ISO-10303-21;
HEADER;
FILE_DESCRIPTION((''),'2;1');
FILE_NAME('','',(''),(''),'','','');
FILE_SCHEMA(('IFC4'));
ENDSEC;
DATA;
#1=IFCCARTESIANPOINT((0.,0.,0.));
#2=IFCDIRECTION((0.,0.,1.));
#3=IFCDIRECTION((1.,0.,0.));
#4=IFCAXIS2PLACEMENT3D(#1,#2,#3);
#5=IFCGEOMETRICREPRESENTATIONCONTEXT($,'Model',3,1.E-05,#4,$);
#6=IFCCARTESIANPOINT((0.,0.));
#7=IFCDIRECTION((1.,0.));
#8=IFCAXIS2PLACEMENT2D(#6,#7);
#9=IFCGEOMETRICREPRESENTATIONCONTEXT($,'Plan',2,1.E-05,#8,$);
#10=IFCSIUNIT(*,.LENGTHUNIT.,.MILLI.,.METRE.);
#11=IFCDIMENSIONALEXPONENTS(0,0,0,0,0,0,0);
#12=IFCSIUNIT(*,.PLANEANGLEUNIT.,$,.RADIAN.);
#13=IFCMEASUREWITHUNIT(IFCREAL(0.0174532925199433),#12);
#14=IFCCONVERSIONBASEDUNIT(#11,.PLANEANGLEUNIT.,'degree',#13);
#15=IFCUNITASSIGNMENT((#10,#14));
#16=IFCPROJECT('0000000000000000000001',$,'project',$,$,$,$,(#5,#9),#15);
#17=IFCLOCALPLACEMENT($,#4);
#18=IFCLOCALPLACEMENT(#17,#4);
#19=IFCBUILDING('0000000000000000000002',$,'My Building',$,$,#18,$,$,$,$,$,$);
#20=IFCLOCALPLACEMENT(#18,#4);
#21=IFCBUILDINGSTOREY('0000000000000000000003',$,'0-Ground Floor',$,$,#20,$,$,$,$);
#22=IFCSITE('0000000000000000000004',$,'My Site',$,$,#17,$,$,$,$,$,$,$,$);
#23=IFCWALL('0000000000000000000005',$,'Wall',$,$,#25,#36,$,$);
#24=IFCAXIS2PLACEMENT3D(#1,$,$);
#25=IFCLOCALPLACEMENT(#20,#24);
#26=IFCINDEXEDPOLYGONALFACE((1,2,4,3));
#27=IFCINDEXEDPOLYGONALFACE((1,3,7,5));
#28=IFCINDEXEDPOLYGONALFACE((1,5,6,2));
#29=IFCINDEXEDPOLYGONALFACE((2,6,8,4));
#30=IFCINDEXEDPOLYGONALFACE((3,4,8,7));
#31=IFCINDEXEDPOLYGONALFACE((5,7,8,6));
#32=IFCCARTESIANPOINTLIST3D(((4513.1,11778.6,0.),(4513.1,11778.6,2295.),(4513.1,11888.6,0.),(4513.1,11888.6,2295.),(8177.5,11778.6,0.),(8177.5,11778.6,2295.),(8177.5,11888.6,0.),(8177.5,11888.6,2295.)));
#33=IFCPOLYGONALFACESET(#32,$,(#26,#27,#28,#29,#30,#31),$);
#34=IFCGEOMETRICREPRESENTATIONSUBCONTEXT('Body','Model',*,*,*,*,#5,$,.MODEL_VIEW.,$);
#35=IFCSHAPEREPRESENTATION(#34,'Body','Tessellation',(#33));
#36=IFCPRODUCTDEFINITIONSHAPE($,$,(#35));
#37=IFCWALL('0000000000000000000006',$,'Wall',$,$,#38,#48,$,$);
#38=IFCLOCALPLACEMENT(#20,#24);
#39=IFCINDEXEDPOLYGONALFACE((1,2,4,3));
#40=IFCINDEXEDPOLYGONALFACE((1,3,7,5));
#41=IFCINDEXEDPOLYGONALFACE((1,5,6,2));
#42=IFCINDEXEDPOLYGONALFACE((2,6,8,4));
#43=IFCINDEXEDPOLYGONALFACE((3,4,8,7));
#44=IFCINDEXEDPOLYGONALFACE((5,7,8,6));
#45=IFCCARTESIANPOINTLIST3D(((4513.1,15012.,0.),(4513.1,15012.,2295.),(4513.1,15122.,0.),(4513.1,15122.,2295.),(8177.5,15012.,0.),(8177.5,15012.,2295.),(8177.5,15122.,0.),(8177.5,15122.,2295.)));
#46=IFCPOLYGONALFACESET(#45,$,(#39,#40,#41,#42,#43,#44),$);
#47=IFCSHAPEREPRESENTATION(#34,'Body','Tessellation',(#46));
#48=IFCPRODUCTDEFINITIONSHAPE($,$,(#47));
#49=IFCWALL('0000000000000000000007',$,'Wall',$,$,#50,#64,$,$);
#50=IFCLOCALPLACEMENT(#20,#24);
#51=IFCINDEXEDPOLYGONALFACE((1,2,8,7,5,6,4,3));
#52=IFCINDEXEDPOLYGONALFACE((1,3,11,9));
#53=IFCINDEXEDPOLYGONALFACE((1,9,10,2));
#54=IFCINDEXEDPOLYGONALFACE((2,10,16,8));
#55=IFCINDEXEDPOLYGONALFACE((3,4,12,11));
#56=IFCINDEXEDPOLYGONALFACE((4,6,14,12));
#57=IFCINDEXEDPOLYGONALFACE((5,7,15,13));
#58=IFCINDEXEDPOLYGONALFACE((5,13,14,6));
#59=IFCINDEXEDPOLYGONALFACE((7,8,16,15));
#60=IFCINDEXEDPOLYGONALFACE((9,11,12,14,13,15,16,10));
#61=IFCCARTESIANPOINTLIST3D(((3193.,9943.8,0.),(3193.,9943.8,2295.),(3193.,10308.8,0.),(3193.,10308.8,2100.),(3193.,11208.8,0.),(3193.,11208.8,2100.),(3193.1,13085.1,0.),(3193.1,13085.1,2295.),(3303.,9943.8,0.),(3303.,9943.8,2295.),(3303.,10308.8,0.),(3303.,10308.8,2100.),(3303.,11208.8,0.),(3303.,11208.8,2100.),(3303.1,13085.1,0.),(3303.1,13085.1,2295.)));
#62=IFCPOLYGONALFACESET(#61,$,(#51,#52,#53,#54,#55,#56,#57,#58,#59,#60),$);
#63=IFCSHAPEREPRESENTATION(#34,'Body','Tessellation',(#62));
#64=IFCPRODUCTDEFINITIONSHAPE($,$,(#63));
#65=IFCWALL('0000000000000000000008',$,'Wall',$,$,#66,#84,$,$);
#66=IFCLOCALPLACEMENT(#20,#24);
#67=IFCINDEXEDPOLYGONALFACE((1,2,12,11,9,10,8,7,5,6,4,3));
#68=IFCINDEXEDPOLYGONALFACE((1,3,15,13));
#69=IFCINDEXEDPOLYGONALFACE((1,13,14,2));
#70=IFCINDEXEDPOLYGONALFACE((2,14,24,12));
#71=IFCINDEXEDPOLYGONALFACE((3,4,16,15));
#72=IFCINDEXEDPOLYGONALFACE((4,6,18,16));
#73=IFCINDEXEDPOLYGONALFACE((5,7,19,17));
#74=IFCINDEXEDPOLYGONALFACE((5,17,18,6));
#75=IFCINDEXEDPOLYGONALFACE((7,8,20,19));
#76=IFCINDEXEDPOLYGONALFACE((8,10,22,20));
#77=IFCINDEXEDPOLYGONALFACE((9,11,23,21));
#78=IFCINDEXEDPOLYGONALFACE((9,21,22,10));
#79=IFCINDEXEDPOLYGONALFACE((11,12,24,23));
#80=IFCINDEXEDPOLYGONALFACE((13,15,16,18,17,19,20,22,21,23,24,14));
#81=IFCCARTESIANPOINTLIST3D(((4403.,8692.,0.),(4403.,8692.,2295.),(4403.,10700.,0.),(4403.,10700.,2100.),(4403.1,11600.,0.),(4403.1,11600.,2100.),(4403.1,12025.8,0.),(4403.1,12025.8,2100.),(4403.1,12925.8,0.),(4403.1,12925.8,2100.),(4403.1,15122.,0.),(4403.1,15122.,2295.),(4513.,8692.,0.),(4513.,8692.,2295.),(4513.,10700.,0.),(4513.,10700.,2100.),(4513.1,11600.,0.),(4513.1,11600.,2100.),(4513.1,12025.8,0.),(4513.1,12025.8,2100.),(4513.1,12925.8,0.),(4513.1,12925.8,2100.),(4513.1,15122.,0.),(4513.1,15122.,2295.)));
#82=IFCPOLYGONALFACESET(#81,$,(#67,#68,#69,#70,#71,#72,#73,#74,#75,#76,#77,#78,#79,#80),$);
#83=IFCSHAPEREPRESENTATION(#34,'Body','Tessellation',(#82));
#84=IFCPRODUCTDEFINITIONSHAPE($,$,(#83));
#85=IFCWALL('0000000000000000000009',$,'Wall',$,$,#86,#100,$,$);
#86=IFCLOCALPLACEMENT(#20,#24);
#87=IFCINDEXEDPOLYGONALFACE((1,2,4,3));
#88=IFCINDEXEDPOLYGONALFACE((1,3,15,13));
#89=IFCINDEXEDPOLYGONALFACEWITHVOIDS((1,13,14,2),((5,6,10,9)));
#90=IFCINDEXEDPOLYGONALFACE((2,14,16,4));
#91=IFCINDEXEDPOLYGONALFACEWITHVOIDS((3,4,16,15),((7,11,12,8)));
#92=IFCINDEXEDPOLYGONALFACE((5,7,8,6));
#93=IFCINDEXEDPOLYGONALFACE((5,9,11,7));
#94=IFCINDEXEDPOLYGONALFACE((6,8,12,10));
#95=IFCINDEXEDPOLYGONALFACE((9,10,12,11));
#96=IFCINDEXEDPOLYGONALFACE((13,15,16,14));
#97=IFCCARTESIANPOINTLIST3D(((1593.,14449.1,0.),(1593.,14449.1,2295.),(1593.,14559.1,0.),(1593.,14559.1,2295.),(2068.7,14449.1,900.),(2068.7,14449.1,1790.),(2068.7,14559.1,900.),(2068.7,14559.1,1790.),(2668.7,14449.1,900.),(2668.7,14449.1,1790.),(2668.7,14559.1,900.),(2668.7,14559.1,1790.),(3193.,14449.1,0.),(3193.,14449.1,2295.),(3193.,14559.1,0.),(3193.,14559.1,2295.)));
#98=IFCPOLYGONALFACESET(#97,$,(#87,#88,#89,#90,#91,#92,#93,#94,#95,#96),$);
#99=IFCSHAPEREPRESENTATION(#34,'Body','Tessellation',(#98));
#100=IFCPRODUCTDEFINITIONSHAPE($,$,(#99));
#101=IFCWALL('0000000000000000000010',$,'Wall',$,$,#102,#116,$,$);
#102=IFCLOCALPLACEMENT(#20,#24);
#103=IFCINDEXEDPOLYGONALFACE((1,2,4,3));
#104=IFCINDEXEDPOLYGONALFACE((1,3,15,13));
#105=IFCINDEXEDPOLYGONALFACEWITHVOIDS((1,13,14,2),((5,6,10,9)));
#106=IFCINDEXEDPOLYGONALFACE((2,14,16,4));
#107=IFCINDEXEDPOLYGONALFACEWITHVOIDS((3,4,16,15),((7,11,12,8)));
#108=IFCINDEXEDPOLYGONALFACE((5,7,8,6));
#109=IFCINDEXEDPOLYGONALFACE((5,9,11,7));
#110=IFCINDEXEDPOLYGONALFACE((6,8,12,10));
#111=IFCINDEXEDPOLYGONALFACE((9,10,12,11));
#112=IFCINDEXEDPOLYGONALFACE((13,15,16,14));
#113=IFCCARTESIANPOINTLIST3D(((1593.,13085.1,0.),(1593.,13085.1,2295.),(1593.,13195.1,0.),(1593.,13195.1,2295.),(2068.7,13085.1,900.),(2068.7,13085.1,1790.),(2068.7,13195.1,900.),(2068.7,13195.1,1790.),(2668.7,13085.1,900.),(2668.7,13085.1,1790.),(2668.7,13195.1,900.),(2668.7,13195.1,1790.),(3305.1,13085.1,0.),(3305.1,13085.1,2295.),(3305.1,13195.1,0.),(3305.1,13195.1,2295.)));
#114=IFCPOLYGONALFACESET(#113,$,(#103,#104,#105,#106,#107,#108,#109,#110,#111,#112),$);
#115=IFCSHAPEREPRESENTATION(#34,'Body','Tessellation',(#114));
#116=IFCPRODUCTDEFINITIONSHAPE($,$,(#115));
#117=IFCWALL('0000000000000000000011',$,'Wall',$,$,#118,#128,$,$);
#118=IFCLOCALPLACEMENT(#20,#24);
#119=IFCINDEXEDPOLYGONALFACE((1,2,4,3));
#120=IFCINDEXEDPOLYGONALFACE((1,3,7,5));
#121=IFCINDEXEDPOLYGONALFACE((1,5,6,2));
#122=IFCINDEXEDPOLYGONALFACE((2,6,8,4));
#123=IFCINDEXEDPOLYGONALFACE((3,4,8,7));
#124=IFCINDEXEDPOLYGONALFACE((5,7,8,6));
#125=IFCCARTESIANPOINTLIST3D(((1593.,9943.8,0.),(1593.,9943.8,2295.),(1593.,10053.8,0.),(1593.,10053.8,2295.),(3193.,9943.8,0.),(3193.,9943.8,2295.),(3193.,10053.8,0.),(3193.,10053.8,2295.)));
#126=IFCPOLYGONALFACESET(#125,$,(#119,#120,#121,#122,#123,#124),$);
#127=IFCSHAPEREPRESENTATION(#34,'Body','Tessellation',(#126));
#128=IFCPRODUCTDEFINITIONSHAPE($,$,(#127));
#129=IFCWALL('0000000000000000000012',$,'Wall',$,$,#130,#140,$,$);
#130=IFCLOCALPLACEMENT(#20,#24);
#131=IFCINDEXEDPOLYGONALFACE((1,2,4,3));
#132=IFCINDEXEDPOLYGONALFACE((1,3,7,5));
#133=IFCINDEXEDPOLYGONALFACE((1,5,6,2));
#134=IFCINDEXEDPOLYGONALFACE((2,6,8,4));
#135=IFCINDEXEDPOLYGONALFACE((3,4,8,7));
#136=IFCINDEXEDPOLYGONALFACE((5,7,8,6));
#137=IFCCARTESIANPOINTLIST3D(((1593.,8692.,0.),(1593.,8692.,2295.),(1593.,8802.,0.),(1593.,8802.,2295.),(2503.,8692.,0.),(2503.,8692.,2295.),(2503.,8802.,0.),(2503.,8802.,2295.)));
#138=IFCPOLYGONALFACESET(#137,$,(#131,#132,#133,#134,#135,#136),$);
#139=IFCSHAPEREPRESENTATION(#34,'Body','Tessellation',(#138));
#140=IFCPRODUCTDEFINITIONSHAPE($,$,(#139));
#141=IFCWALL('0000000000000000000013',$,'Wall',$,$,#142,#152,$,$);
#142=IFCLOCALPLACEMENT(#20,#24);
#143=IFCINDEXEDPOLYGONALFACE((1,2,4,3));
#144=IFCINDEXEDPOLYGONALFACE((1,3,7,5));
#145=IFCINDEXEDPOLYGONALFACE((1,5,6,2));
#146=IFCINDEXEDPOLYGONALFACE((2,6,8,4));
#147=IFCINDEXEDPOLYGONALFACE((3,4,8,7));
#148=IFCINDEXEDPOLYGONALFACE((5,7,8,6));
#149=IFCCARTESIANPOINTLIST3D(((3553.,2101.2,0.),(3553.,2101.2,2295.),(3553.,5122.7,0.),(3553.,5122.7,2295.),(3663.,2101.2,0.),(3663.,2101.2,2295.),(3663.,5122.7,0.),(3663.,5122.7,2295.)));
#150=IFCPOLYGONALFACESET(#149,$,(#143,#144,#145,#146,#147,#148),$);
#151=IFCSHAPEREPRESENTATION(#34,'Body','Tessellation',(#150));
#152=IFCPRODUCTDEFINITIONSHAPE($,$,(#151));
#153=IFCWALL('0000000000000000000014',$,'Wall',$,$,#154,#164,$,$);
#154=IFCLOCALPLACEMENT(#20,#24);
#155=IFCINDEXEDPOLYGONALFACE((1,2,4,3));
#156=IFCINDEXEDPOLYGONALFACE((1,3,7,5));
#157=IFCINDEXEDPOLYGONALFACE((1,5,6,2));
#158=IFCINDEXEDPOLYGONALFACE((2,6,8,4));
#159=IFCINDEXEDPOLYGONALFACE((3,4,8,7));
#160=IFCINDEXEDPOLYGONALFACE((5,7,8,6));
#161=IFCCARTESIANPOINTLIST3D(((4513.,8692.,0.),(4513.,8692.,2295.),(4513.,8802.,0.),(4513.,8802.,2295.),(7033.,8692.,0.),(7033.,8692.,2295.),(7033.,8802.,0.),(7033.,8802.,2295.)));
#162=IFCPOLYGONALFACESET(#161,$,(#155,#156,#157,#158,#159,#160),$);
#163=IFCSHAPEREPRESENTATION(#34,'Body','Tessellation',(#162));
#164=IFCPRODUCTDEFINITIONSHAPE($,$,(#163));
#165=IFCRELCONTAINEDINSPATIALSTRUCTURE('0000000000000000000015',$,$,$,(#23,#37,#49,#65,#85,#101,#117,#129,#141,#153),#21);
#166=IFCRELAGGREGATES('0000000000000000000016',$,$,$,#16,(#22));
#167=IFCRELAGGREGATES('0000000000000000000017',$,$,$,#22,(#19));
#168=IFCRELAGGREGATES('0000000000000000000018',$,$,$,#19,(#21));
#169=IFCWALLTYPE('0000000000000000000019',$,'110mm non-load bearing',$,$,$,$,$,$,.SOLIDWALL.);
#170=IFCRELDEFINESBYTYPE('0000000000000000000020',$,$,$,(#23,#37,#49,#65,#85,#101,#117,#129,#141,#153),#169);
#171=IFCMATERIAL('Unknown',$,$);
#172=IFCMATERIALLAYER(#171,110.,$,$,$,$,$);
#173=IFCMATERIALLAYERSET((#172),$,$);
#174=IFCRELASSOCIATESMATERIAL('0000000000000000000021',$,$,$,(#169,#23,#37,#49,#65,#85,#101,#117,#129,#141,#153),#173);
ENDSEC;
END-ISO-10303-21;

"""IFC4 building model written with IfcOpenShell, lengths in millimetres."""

from ifc_helpers import new_model, entity, si_unit, converted_unit, frame, origin_with_axes, origin_2d_with_axis, place, context, subcontext, project, spatial, line, indexed_curve, outline, extrude, source, transform, mapped, material, layer, layer_set, layer_usage, type_object, element, save


model = new_model("IFC4")

# Units and contexts
model_context = context("Model", 3, precision=1e-05, world=origin_with_axes())
plan_context = context("Plan", 2, precision=1e-05, world=origin_2d_with_axis())
body_context_1 = subcontext(model_context, "Body", "Model", "MODEL_VIEW")
ifc_project = project(units=[si_unit("LENGTHUNIT", "METRE", prefix="MILLI"), converted_unit("PLANEANGLEUNIT", "degree", entity("IfcReal", 0.0174532925199433), si_unit("PLANEANGLEUNIT", "RADIAN"), dimensions=[0, 0, 0, 0, 0, 0, 0])], contexts=[model_context, plan_context])

# Site, building, storey
site_placement = place(None, origin_with_axes())
site = spatial("IfcSite", under=ifc_project, at=site_placement, Name="My Site")
building_placement = place(site_placement, origin_with_axes())
building = spatial("IfcBuilding", under=site, at=building_placement, Name="My Building")
storey_placement = place(building_placement, origin_with_axes())
storey = spatial("IfcBuildingStorey", under=building, at=storey_placement, Name="0-Ground Floor")

# Walls
ifc_material_1 = material(Name="Unknown")
ifc_layer_1 = layer(ifc_material_1, 110.0)
ifc_layer_set_1 = layer_set([ifc_layer_1])
ifc_layer_usage_1 = layer_usage(ifc_layer_set_1, "AXIS2", "POSITIVE", 0.0)
wall_type_1 = type_object("IfcWallType", Name="110mm non-load bearing", PredefinedType="SOLIDWALL", material=ifc_layer_set_1)
wall_1_placement = place(storey_placement, frame((4513.1, 11778.6, 0.0), z_axis=(0.0, 0.0, 1.0), x_axis=(1.0, 0.0, 0.0)))
element("IfcWall", 1, at=wall_1_placement, inside=storey, type_object=wall_type_1, material=ifc_layer_usage_1, Name="Wall", context=body_context_1, shape_type="SweptSolid", body=[
    extrude(outline(indexed_curve([(0.0, 0.0), (0.0, 110.0), (3664.5, 110.0), (3664.5, 0.0), (0.0, 0.0)], self_intersect=False)), origin_with_axes(), (0.0, 0.0, 1.0), 2295.0),
])
ifc_layer_usage_2 = layer_usage(ifc_layer_set_1, "AXIS2", "POSITIVE", 0.0)
wall_2_placement = place(storey_placement, frame((4513.1, 15012.0, 0.0), z_axis=(0.0, 0.0, 1.0), x_axis=(1.0, 0.0, 0.0)))
element("IfcWall", 2, at=wall_2_placement, inside=storey, type_object=wall_type_1, material=ifc_layer_usage_2, Name="Wall", context=body_context_1, shape_type="SweptSolid", body=[
    extrude(outline(indexed_curve([(0.0, 0.0), (0.0, 110.0), (3664.5, 110.0), (3664.5, 0.0), (0.0, 0.0)], self_intersect=False)), origin_with_axes(), (0.0, 0.0, 1.0), 2295.0),
])

# Wall, opening
ifc_layer_usage_3 = layer_usage(ifc_layer_set_1, "AXIS2", "POSITIVE", 0.0)
wall_3_placement = place(storey_placement, frame((3303.0, 9943.8, 0.0), z_axis=(0.0, 0.0, 1.0), x_axis=(0.0, 1.0, 0.0)))
wall_3 = element("IfcWall", 3, at=wall_3_placement, inside=storey, type_object=wall_type_1, material=ifc_layer_usage_3, Name="Wall", context=body_context_1, shape_type="SweptSolid", body=[
    extrude(outline(indexed_curve([(0.0, 0.0), (0.0, 110.0), (3141.4, 110.0), (3141.4, 0.0), (0.0, 0.0)], self_intersect=False)), origin_with_axes(), (0.0, 0.0, 1.0), 2295.0),
])
shared_shape_1 = source(origin_with_axes(), body_context_1, "Body", "SweptSolid", [
    extrude(outline(indexed_curve([(0.0, 0.0), (900.0, 0.0), (900.0, 2100.0), (0.0, 2100.0)], segments=[line(1, 2, 3, 4, 1)])), frame((0.0, -600.0, 0.0), z_axis=(0.0, -1.0, 0.0), x_axis=(1.0, 0.0, 0.0)), (0.0, 0.0, -1.0), 1200.0),
])
opening_1_placement = place(wall_3_placement, frame((365.0, 20.0, 0.0), z_axis=(0.0, 0.0, 1.0), x_axis=(1.0, 0.0, 0.0)))
element("IfcOpeningElement", 4, at=opening_1_placement, cuts=wall_3, PredefinedType="OPENING", context=body_context_1, shape_type="MappedRepresentation", body=[
    mapped(shared_shape_1, transform((0.0, 0.0, 0.0), x_axis=(1.0, 0.0, 0.0), y_axis=(0.0, 1.0, 0.0), z_axis=(0.0, 0.0, 1.0), scale=1.0)),
])

# Wall, openings
ifc_layer_usage_4 = layer_usage(ifc_layer_set_1, "AXIS2", "POSITIVE", 0.0)
wall_4_placement = place(storey_placement, frame((4513.0, 8692.0, 0.0), z_axis=(0.0, 0.0, 1.0), x_axis=(0.0, 1.0, 0.0)))
wall_4 = element("IfcWall", 5, at=wall_4_placement, inside=storey, type_object=wall_type_1, material=ifc_layer_usage_4, Name="Wall", context=body_context_1, shape_type="SweptSolid", body=[
    extrude(outline(indexed_curve([(0.0, 0.0), (0.0, 110.0), (6430.0, 110.0), (6430.0, 0.0), (0.0, 0.0)], self_intersect=False)), origin_with_axes(), (0.0, 0.0, 1.0), 2295.0),
])
shared_shape_2 = source(origin_with_axes(), body_context_1, "Body", "SweptSolid", [
    extrude(outline(indexed_curve([(0.0, 0.0), (900.0, 0.0), (900.0, 2100.0), (0.0, 2100.0)], segments=[line(1, 2, 3, 4, 1)])), frame((0.0, -600.0, 0.0), z_axis=(0.0, -1.0, 0.0), x_axis=(1.0, 0.0, 0.0)), (0.0, 0.0, -1.0), 1200.0),
])
opening_2_placement = place(wall_4_placement, frame((2008.1, -80.0, 0.0), z_axis=(0.0, 0.0, 1.0), x_axis=(1.0, 0.0, 0.0)))
element("IfcOpeningElement", 6, at=opening_2_placement, cuts=wall_4, PredefinedType="OPENING", context=body_context_1, shape_type="MappedRepresentation", body=[
    mapped(shared_shape_2, transform((0.0, 0.0, 0.0), x_axis=(1.0, 0.0, 0.0), y_axis=(0.0, 1.0, 0.0), z_axis=(0.0, 0.0, 1.0), scale=1.0)),
])
opening_3_placement = place(wall_4_placement, frame((3333.9, -80.0, 0.0), z_axis=(0.0, 0.0, 1.0), x_axis=(1.0, 0.0, 0.0)))
element("IfcOpeningElement", 7, at=opening_3_placement, cuts=wall_4, PredefinedType="OPENING", context=body_context_1, shape_type="MappedRepresentation", body=[
    mapped(shared_shape_2, transform((0.0, 0.0, 0.0), x_axis=(1.0, 0.0, 0.0), y_axis=(0.0, 1.0, 0.0), z_axis=(0.0, 0.0, 1.0), scale=1.0)),
])

# Walls, openings
ifc_layer_usage_5 = layer_usage(ifc_layer_set_1, "AXIS2", "POSITIVE", 0.0)
wall_5_placement = place(storey_placement, frame((1593.0, 14449.1, 0.0), z_axis=(0.0, 0.0, 1.0), x_axis=(1.0, 0.0, 0.0)))
wall_5 = element("IfcWall", 8, at=wall_5_placement, inside=storey, type_object=wall_type_1, material=ifc_layer_usage_5, Name="Wall", context=body_context_1, shape_type="SweptSolid", body=[
    extrude(outline(indexed_curve([(0.0, 0.0), (0.0, 110.0), (1600.0, 110.0), (1600.0, 0.0), (0.0, 0.0)], self_intersect=False)), origin_with_axes(), (0.0, 0.0, 1.0), 2295.0),
])
shared_shape_3 = source(origin_with_axes(), body_context_1, "Body", "SweptSolid", [
    extrude(outline(indexed_curve([(0.0, 0.0), (600.0, 0.0), (600.0, 890.0), (0.0, 890.0)], segments=[line(1, 2, 3, 4, 1)])), frame((0.0, -600.0, 0.0), z_axis=(0.0, -1.0, 0.0), x_axis=(1.0, 0.0, 0.0)), (0.0, 0.0, -1.0), 1200.0),
])
opening_4_placement = place(wall_5_placement, frame((475.7, 0.0, 900.0), z_axis=(0.0, 0.0, 1.0), x_axis=(1.0, 0.0, 0.0)))
element("IfcOpeningElement", 9, at=opening_4_placement, cuts=wall_5, PredefinedType="OPENING", context=body_context_1, shape_type="MappedRepresentation", body=[
    mapped(shared_shape_3, transform((0.0, 0.0, 0.0), x_axis=(1.0, 0.0, 0.0), y_axis=(0.0, 1.0, 0.0), z_axis=(0.0, 0.0, 1.0), scale=1.0)),
])
ifc_layer_usage_6 = layer_usage(ifc_layer_set_1, "AXIS2", "POSITIVE", 0.0)
wall_6_placement = place(storey_placement, frame((1593.0, 13085.1, 0.0), z_axis=(0.0, 0.0, 1.0), x_axis=(1.0, 0.0, 0.0)))
wall_6 = element("IfcWall", 10, at=wall_6_placement, inside=storey, type_object=wall_type_1, material=ifc_layer_usage_6, Name="Wall", context=body_context_1, shape_type="SweptSolid", body=[
    extrude(outline(indexed_curve([(0.0, 0.0), (0.0, 110.0), (1712.0, 110.0), (1712.0, 0.0), (0.0, 0.0)], self_intersect=False)), origin_with_axes(), (0.0, 0.0, 1.0), 2295.0),
])
opening_5_placement = place(wall_6_placement, frame((475.7, 0.0, 900.0), z_axis=(0.0, 0.0, 1.0), x_axis=(1.0, 0.0, 0.0)))
element("IfcOpeningElement", 11, at=opening_5_placement, cuts=wall_6, PredefinedType="OPENING", context=body_context_1, shape_type="MappedRepresentation", body=[
    mapped(shared_shape_3, transform((0.0, 0.0, 0.0), x_axis=(1.0, 0.0, 0.0), y_axis=(0.0, 1.0, 0.0), z_axis=(0.0, 0.0, 1.0), scale=1.0)),
])

# Walls
ifc_layer_usage_7 = layer_usage(ifc_layer_set_1, "AXIS2", "POSITIVE", 0.0)
wall_7_placement = place(storey_placement, frame((1593.0, 9943.8, 0.0), z_axis=(0.0, 0.0, 1.0), x_axis=(1.0, 0.0, 0.0)))
element("IfcWall", 12, at=wall_7_placement, inside=storey, type_object=wall_type_1, material=ifc_layer_usage_7, Name="Wall", context=body_context_1, shape_type="SweptSolid", body=[
    extrude(outline(indexed_curve([(0.0, 0.0), (0.0, 110.0), (1600.0, 110.0), (1600.0, 0.0), (0.0, 0.0)], self_intersect=False)), origin_with_axes(), (0.0, 0.0, 1.0), 2295.0),
])
ifc_layer_usage_8 = layer_usage(ifc_layer_set_1, "AXIS2", "POSITIVE", 0.0)
wall_8_placement = place(storey_placement, frame((1593.0, 8692.0, 0.0), z_axis=(0.0, 0.0, 1.0), x_axis=(1.0, 0.0, 0.0)))
element("IfcWall", 13, at=wall_8_placement, inside=storey, type_object=wall_type_1, material=ifc_layer_usage_8, Name="Wall", context=body_context_1, shape_type="SweptSolid", body=[
    extrude(outline(indexed_curve([(0.0, 0.0), (0.0, 110.0), (910.0, 110.0), (910.0, 0.0), (0.0, 0.0)], self_intersect=False)), origin_with_axes(), (0.0, 0.0, 1.0), 2295.0),
])
ifc_layer_usage_9 = layer_usage(ifc_layer_set_1, "AXIS2", "POSITIVE", 0.0)
wall_9_placement = place(storey_placement, frame((3663.0, 2101.2, 0.0), z_axis=(0.0, 0.0, 1.0), x_axis=(0.0, 1.0, 0.0)))
element("IfcWall", 14, at=wall_9_placement, inside=storey, type_object=wall_type_1, material=ifc_layer_usage_9, Name="Wall", context=body_context_1, shape_type="SweptSolid", body=[
    extrude(outline(indexed_curve([(0.0, 0.0), (0.0, 110.0), (3021.6, 110.0), (3021.6, 0.0), (0.0, 0.0)], self_intersect=False)), origin_with_axes(), (0.0, 0.0, 1.0), 2295.0),
])
ifc_layer_usage_10 = layer_usage(ifc_layer_set_1, "AXIS2", "POSITIVE", 0.0)
wall_10_placement = place(storey_placement, frame((4513.0, 8692.0, 0.0), z_axis=(0.0, 0.0, 1.0), x_axis=(1.0, 0.0, 0.0)))
element("IfcWall", 15, at=wall_10_placement, inside=storey, type_object=wall_type_1, material=ifc_layer_usage_10, Name="Wall", context=body_context_1, shape_type="SweptSolid", body=[
    extrude(outline(indexed_curve([(0.0, 0.0), (0.0, 110.0), (2520.0, 110.0), (2520.0, 0.0), (0.0, 0.0)], self_intersect=False)), origin_with_axes(), (0.0, 0.0, 1.0), 2295.0),
])

save(model, "model.ifc")
